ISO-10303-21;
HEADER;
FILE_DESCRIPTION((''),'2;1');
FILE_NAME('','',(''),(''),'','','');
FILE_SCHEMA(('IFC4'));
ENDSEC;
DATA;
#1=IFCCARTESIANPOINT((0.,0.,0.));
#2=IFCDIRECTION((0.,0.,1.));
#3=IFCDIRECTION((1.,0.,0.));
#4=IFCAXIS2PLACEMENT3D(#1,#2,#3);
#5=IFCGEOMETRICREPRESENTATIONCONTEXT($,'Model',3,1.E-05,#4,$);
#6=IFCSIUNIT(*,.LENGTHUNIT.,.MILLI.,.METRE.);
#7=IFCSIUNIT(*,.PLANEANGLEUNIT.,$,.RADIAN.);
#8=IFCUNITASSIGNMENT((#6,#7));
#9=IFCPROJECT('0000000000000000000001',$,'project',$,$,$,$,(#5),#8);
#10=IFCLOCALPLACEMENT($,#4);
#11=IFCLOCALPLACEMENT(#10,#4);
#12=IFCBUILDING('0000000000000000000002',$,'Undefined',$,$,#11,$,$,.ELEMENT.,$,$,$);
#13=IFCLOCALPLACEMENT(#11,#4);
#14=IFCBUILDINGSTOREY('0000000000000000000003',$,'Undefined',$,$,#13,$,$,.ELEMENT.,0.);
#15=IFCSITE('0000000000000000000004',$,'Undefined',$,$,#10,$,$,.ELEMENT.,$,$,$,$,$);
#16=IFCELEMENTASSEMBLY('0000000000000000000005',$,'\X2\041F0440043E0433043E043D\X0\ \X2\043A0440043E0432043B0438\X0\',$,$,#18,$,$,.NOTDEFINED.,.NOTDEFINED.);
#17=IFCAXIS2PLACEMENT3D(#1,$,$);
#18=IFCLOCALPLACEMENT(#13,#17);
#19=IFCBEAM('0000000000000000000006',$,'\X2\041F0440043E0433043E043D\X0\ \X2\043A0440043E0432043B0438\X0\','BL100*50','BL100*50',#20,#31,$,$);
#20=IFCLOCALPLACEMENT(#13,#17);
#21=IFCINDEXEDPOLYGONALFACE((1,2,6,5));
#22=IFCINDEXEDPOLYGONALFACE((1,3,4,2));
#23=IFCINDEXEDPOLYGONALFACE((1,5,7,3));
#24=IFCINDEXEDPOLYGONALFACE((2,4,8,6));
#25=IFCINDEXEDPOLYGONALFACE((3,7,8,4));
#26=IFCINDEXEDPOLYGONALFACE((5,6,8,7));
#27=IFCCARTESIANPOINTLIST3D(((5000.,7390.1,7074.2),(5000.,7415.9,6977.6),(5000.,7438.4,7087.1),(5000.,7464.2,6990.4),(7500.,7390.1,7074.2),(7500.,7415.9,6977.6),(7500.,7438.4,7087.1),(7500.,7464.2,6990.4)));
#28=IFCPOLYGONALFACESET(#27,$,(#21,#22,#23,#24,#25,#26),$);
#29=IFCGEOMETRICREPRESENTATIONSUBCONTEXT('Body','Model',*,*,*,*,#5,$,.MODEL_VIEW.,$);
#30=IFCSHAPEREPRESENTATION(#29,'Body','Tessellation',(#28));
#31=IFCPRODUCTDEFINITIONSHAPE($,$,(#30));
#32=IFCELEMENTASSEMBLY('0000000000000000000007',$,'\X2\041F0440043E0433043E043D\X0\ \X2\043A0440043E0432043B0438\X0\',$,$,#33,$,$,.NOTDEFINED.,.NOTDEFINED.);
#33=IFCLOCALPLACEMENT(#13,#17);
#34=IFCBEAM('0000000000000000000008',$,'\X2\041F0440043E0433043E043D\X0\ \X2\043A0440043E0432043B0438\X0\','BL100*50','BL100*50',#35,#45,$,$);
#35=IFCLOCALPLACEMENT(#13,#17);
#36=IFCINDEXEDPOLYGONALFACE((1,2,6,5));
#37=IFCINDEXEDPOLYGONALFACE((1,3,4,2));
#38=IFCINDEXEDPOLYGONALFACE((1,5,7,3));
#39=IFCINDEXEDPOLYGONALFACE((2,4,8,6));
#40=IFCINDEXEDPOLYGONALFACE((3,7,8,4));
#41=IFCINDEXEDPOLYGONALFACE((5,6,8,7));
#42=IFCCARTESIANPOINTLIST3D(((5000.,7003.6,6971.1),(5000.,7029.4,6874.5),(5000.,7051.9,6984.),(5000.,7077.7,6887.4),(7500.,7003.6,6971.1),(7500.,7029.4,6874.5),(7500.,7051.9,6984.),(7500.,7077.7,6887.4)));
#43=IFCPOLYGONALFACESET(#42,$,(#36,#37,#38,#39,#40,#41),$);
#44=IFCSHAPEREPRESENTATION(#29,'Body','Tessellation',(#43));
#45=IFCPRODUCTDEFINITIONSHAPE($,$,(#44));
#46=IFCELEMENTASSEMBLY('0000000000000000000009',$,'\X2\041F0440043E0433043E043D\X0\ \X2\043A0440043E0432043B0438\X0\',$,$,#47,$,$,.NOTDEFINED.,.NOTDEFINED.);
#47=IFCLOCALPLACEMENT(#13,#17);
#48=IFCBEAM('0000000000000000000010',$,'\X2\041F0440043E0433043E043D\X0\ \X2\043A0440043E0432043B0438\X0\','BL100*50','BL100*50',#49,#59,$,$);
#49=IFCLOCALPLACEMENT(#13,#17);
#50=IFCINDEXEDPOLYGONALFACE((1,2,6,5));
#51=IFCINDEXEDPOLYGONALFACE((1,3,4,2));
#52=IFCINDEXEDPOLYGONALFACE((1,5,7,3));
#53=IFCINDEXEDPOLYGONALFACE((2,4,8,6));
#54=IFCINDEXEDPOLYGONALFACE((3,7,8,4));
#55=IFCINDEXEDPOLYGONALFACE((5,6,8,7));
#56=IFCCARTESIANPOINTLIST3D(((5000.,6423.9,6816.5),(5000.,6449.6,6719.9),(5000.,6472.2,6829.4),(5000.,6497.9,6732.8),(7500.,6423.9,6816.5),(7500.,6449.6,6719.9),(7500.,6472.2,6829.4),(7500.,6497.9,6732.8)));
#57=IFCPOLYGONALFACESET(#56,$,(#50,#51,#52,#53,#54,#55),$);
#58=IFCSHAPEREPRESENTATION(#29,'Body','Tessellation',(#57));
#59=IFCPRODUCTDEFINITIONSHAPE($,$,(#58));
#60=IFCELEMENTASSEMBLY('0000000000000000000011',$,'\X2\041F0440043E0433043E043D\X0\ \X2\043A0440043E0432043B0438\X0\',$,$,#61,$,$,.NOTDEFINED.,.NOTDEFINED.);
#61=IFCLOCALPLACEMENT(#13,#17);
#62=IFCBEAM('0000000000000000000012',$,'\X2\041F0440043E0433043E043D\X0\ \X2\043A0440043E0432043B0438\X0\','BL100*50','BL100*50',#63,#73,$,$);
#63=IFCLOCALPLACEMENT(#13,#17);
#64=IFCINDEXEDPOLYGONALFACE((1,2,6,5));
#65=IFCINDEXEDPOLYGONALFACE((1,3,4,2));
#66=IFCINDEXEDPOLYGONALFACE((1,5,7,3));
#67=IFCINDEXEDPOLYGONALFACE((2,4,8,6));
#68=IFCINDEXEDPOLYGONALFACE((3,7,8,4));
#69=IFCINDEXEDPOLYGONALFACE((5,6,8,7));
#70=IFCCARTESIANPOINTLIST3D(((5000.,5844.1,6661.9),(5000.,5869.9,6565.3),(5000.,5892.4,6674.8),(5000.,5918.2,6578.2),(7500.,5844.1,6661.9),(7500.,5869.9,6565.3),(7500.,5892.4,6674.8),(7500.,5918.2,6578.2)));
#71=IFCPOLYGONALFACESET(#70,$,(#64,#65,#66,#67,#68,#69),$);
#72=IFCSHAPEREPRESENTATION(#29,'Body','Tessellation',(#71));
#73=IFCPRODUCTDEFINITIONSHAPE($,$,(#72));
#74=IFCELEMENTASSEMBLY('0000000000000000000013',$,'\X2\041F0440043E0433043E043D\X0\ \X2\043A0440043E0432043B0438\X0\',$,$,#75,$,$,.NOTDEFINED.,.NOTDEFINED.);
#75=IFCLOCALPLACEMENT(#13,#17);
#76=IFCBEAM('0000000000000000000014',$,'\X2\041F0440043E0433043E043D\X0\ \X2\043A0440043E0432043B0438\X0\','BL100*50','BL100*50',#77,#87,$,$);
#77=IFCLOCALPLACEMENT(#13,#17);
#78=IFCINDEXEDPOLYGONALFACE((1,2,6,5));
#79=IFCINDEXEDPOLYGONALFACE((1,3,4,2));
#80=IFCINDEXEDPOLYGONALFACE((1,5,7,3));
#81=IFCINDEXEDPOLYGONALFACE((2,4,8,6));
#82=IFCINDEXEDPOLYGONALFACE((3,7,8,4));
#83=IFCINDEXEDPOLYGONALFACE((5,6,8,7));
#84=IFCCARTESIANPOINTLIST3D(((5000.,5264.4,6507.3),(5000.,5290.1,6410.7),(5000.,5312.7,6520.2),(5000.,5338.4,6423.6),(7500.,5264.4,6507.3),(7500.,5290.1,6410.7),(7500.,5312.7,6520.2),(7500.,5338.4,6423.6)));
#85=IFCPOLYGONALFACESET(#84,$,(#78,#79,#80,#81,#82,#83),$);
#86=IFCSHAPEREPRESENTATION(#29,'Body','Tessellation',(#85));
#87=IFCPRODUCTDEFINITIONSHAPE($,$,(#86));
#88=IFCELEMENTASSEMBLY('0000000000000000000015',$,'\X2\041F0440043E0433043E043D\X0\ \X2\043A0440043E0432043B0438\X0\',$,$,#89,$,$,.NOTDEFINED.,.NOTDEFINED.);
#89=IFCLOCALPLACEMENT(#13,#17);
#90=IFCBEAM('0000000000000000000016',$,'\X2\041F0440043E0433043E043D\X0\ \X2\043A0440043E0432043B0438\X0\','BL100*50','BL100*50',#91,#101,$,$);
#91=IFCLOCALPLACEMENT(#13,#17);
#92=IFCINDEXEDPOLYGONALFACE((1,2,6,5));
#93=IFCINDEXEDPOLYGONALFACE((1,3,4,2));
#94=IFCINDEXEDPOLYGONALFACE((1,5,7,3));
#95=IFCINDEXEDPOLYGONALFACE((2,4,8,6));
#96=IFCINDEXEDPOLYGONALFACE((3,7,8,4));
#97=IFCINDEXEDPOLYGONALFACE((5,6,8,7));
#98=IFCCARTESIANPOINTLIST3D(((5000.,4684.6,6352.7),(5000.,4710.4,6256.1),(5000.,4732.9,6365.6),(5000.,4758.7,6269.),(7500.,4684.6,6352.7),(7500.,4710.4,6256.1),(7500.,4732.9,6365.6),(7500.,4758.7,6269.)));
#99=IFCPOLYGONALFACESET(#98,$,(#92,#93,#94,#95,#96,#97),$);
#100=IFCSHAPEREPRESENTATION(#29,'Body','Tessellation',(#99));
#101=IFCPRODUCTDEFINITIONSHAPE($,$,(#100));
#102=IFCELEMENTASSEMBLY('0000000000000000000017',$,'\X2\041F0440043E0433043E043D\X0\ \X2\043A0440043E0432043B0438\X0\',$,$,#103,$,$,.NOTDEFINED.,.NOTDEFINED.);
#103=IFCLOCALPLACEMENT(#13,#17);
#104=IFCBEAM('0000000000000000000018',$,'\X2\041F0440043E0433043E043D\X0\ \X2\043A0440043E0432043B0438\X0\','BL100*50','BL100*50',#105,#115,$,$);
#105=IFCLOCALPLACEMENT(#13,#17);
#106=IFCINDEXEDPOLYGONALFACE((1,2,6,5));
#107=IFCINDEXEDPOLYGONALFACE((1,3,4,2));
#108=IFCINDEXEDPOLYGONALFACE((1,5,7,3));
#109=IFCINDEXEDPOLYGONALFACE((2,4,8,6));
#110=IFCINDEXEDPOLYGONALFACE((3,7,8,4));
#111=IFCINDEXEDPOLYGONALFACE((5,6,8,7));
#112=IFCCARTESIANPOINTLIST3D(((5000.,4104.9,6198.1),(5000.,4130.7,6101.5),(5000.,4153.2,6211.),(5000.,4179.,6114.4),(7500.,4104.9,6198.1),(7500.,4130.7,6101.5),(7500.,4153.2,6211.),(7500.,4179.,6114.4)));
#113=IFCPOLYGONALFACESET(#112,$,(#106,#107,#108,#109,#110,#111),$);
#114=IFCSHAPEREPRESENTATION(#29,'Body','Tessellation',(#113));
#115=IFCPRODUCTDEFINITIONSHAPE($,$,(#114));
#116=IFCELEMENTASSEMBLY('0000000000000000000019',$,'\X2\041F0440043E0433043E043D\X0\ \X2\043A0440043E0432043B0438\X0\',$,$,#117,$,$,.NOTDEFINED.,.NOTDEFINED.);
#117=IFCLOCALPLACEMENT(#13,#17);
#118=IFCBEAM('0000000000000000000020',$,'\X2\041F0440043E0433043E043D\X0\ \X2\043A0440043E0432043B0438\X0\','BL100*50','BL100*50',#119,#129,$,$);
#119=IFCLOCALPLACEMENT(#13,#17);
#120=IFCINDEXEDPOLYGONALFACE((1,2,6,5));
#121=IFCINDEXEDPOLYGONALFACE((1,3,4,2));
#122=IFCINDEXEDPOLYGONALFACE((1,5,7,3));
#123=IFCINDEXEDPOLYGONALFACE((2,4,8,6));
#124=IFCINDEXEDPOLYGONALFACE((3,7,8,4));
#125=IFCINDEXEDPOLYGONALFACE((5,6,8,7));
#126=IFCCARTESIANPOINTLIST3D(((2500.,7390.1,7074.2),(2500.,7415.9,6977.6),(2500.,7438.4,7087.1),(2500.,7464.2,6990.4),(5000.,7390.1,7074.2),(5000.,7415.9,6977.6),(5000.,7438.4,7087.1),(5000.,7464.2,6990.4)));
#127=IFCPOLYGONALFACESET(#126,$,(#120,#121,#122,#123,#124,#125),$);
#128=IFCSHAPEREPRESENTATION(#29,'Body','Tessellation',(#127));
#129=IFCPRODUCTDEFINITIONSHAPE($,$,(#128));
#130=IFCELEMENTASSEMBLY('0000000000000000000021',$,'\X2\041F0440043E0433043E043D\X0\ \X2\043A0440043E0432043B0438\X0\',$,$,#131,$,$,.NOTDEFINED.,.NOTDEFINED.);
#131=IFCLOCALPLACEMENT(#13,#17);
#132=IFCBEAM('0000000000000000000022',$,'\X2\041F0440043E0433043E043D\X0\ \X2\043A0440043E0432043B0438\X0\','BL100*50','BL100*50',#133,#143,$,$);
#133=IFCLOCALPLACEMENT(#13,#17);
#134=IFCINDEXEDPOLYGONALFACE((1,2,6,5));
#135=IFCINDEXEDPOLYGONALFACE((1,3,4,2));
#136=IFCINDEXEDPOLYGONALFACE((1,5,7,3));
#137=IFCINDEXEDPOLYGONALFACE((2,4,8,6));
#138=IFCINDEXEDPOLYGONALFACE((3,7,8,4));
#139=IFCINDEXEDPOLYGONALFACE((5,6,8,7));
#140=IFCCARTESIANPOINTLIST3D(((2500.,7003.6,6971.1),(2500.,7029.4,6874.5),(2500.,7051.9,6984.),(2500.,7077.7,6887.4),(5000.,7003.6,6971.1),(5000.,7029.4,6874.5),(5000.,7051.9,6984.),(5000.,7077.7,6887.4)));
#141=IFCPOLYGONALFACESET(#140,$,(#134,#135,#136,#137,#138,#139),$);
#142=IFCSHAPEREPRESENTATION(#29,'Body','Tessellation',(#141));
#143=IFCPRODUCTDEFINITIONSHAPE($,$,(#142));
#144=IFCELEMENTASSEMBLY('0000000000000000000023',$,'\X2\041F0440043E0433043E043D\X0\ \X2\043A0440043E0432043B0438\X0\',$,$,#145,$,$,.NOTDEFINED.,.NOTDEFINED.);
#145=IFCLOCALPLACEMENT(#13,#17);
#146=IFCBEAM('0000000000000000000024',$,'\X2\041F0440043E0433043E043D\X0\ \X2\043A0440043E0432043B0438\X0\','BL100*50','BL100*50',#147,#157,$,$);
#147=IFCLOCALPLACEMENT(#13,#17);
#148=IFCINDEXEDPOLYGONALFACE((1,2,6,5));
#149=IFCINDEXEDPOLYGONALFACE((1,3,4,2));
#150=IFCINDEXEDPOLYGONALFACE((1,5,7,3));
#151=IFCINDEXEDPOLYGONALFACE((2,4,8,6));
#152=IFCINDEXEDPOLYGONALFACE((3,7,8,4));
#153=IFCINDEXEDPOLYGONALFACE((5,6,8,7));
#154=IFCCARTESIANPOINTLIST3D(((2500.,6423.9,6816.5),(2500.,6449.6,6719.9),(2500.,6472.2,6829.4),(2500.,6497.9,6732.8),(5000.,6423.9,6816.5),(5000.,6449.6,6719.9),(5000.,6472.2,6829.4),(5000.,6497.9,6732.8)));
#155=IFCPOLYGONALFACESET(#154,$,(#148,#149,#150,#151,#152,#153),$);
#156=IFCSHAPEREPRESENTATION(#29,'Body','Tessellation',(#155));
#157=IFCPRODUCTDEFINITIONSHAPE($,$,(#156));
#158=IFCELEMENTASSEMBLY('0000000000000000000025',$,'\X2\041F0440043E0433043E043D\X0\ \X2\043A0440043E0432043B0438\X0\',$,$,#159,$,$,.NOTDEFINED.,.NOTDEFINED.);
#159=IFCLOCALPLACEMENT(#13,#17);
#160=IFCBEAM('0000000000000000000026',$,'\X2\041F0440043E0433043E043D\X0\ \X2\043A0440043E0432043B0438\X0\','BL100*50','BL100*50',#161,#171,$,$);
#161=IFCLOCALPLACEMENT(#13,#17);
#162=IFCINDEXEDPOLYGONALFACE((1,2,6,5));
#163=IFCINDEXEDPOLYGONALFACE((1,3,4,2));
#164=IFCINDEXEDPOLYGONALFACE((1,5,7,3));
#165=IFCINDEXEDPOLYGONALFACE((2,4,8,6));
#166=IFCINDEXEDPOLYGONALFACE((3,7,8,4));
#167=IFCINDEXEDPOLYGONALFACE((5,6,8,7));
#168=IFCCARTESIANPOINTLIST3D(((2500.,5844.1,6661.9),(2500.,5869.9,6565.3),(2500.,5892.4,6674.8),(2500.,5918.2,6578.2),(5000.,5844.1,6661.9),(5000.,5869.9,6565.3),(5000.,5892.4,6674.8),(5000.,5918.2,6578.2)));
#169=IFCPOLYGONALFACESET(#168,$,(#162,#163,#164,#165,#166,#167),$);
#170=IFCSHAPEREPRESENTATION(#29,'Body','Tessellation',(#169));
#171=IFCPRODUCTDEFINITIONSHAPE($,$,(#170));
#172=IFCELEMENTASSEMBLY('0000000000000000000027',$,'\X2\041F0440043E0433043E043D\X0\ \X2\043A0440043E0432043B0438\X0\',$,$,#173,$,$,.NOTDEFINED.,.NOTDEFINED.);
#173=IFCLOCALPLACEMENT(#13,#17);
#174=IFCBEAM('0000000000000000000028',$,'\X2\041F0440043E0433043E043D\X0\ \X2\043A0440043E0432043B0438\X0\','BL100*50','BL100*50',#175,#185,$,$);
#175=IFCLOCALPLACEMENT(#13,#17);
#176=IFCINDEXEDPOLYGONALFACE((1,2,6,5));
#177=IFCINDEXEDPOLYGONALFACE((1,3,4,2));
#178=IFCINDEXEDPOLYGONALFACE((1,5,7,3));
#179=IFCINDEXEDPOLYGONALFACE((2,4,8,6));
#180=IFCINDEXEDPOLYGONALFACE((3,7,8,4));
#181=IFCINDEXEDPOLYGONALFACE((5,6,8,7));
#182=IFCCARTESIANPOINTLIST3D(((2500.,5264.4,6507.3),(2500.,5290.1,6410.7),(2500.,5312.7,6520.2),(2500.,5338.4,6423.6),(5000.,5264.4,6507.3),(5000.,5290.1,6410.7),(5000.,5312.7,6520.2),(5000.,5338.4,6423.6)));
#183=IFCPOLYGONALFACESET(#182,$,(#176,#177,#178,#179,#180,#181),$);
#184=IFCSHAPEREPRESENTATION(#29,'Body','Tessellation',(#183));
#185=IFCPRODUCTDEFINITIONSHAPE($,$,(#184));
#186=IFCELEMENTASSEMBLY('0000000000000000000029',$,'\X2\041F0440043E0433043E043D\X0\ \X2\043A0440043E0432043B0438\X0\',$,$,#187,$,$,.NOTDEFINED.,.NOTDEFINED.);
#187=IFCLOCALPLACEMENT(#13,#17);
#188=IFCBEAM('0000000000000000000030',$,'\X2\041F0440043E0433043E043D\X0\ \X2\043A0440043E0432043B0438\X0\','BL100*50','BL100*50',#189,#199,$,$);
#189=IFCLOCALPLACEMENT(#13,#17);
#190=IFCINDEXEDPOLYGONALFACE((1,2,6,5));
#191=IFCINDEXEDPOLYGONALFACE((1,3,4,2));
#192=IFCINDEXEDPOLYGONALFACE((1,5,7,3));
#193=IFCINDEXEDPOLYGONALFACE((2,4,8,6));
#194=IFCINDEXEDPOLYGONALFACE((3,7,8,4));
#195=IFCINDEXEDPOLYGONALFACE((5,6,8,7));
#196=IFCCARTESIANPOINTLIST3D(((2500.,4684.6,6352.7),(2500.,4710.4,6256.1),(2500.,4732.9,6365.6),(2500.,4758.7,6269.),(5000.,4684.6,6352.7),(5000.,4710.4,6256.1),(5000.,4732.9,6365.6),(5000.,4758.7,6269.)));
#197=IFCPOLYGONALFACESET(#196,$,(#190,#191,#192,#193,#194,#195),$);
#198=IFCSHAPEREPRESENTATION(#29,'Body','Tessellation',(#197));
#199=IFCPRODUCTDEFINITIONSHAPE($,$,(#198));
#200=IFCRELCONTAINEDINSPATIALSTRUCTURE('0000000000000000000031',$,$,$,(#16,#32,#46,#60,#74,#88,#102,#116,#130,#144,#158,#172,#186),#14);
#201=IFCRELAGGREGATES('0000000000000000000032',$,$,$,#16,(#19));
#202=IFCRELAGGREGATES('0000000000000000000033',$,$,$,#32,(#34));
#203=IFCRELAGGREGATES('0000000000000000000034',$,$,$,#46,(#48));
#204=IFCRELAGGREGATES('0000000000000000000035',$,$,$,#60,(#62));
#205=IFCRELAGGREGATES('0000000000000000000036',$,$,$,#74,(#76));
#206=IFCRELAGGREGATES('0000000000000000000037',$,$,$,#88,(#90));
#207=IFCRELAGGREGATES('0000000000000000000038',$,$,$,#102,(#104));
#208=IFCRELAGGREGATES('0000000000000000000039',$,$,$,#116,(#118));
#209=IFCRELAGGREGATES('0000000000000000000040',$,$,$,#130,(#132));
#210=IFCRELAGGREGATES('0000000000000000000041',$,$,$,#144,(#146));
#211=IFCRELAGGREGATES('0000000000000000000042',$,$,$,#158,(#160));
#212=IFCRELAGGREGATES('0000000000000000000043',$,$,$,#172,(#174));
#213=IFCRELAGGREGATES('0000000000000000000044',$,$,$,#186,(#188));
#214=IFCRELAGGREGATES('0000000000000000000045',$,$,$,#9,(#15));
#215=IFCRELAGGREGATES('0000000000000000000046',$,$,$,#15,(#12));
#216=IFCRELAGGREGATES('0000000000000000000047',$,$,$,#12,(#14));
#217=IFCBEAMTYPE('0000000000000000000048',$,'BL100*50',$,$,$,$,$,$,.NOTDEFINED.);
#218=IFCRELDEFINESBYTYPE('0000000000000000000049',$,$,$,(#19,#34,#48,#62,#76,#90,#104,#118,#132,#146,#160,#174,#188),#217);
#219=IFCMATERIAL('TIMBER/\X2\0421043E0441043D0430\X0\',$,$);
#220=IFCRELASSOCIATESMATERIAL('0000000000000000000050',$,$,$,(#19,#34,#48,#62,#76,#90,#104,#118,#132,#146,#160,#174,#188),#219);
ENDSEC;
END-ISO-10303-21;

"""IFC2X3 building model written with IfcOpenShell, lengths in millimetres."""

from ifc_helpers import new_model, si_unit, frame, origin_with_axes, origin_2d_with_axis, place, context, subcontext, project, spatial, rectangle, extrude, material, type_object, element, aggregate, save


model = new_model("IFC2X3")

# Units and contexts
model_context = context("Model", 3, precision=1e-05, world=origin_with_axes())
body_context = subcontext(model_context, "Body", "Model", "MODEL_VIEW")
ifc_project = project(units=[si_unit("LENGTHUNIT", "METRE", prefix="MILLI"), si_unit("PLANEANGLEUNIT", "RADIAN")], contexts=[model_context])

# Site, building, storey
site_placement = place(None, origin_with_axes())
site = spatial("IfcSite", under=ifc_project, at=site_placement, Name="Undefined", CompositionType="ELEMENT")
building_placement = place(site_placement, origin_with_axes())
building = spatial("IfcBuilding", under=site, at=building_placement, Name="Undefined", CompositionType="ELEMENT")
storey_placement = place(building_placement, origin_with_axes())
storey = spatial("IfcBuildingStorey", under=building, at=storey_placement, Name="Undefined", CompositionType="ELEMENT", Elevation=0.0)

# Element assemblies, beams
assembly_1_placement = place(storey_placement, origin_with_axes())
assembly_1 = element("IfcElementAssembly", 1, at=assembly_1_placement, inside=storey, Name="Прогон кровли", AssemblyPlace="NOTDEFINED", PredefinedType="NOTDEFINED")
ifc_material_1 = material(Name="TIMBER/Сосна")
beam_type = type_object("IfcBeamType", Name="BL100*50", PredefinedType="NOTDEFINED")
beam_1_placement = place(assembly_1_placement, frame((5000.0, 7427.1, 7032.3), z_axis=(0.0, 0.257663, -0.966235), x_axis=(1.0, 0.0, 0.0)))
beam_1 = element("IfcBeam", 2, at=beam_1_placement, type_object=beam_type, material=ifc_material_1, Name="Прогон кровли", Description="BL100*50", ObjectType="BL100*50", context=body_context, shape_type="SweptSolid", body=[
    extrude(rectangle(XDim=50.0, YDim=100.0, at=origin_2d_with_axis()), frame((2500.0, 0.0, 0.0), z_axis=(-1.0, 0.0, 0.0), x_axis=(0.0, -1.0, 0.0)), (0.0, 0.0, 1.0), 2500.0),
])
aggregate(assembly_1, [beam_1])
assembly_2_placement = place(storey_placement, origin_with_axes())
assembly_2 = element("IfcElementAssembly", 3, at=assembly_2_placement, inside=storey, Name="Прогон кровли", AssemblyPlace="NOTDEFINED", PredefinedType="NOTDEFINED")
beam_2_placement = place(assembly_2_placement, frame((5000.0, 7040.6, 6929.2), z_axis=(0.0, 0.257663, -0.966235), x_axis=(1.0, 0.0, 0.0)))
beam_2 = element("IfcBeam", 4, at=beam_2_placement, type_object=beam_type, material=ifc_material_1, Name="Прогон кровли", Description="BL100*50", ObjectType="BL100*50", context=body_context, shape_type="SweptSolid", body=[
    extrude(rectangle(XDim=50.0, YDim=100.0, at=origin_2d_with_axis()), frame((2500.0, 0.0, 0.0), z_axis=(-1.0, 0.0, 0.0), x_axis=(0.0, -1.0, 0.0)), (0.0, 0.0, 1.0), 2500.0),
])
aggregate(assembly_2, [beam_2])
assembly_3_placement = place(storey_placement, origin_with_axes())
assembly_3 = element("IfcElementAssembly", 5, at=assembly_3_placement, inside=storey, Name="Прогон кровли", AssemblyPlace="NOTDEFINED", PredefinedType="NOTDEFINED")
beam_3_placement = place(assembly_3_placement, frame((5000.0, 6460.9, 6774.7), z_axis=(0.0, 0.257663, -0.966235), x_axis=(1.0, 0.0, 0.0)))
beam_3 = element("IfcBeam", 6, at=beam_3_placement, type_object=beam_type, material=ifc_material_1, Name="Прогон кровли", Description="BL100*50", ObjectType="BL100*50", context=body_context, shape_type="SweptSolid", body=[
    extrude(rectangle(XDim=50.0, YDim=100.0, at=origin_2d_with_axis()), frame((2500.0, 0.0, 0.0), z_axis=(-1.0, 0.0, 0.0), x_axis=(0.0, -1.0, 0.0)), (0.0, 0.0, 1.0), 2500.0),
])
aggregate(assembly_3, [beam_3])
assembly_4_placement = place(storey_placement, origin_with_axes())
assembly_4 = element("IfcElementAssembly", 7, at=assembly_4_placement, inside=storey, Name="Прогон кровли", AssemblyPlace="NOTDEFINED", PredefinedType="NOTDEFINED")
beam_4_placement = place(assembly_4_placement, frame((5000.0, 5881.1, 6620.1), z_axis=(0.0, 0.257663, -0.966235), x_axis=(1.0, 0.0, 0.0)))
beam_4 = element("IfcBeam", 8, at=beam_4_placement, type_object=beam_type, material=ifc_material_1, Name="Прогон кровли", Description="BL100*50", ObjectType="BL100*50", context=body_context, shape_type="SweptSolid", body=[
    extrude(rectangle(XDim=50.0, YDim=100.0, at=origin_2d_with_axis()), frame((2500.0, 0.0, 0.0), z_axis=(-1.0, 0.0, 0.0), x_axis=(0.0, -1.0, 0.0)), (0.0, 0.0, 1.0), 2500.0),
])
aggregate(assembly_4, [beam_4])
assembly_5_placement = place(storey_placement, origin_with_axes())
assembly_5 = element("IfcElementAssembly", 9, at=assembly_5_placement, inside=storey, Name="Прогон кровли", AssemblyPlace="NOTDEFINED", PredefinedType="NOTDEFINED")
beam_5_placement = place(assembly_5_placement, frame((5000.0, 5301.4, 6465.5), z_axis=(0.0, 0.257663, -0.966235), x_axis=(1.0, 0.0, 0.0)))
beam_5 = element("IfcBeam", 10, at=beam_5_placement, type_object=beam_type, material=ifc_material_1, Name="Прогон кровли", Description="BL100*50", ObjectType="BL100*50", context=body_context, shape_type="SweptSolid", body=[
    extrude(rectangle(XDim=50.0, YDim=100.0, at=origin_2d_with_axis()), frame((2500.0, 0.0, 0.0), z_axis=(-1.0, 0.0, 0.0), x_axis=(0.0, -1.0, 0.0)), (0.0, 0.0, 1.0), 2500.0),
])
aggregate(assembly_5, [beam_5])
assembly_6_placement = place(storey_placement, origin_with_axes())
assembly_6 = element("IfcElementAssembly", 11, at=assembly_6_placement, inside=storey, Name="Прогон кровли", AssemblyPlace="NOTDEFINED", PredefinedType="NOTDEFINED")
beam_6_placement = place(assembly_6_placement, frame((5000.0, 4721.7, 6310.9), z_axis=(0.0, 0.257663, -0.966235), x_axis=(1.0, 0.0, 0.0)))
beam_6 = element("IfcBeam", 12, at=beam_6_placement, type_object=beam_type, material=ifc_material_1, Name="Прогон кровли", Description="BL100*50", ObjectType="BL100*50", context=body_context, shape_type="SweptSolid", body=[
    extrude(rectangle(XDim=50.0, YDim=100.0, at=origin_2d_with_axis()), frame((2500.0, 0.0, 0.0), z_axis=(-1.0, 0.0, 0.0), x_axis=(0.0, -1.0, 0.0)), (0.0, 0.0, 1.0), 2500.0),
])
aggregate(assembly_6, [beam_6])
assembly_7_placement = place(storey_placement, origin_with_axes())
assembly_7 = element("IfcElementAssembly", 13, at=assembly_7_placement, inside=storey, Name="Прогон кровли", AssemblyPlace="NOTDEFINED", PredefinedType="NOTDEFINED")
beam_7_placement = place(assembly_7_placement, frame((5000.0, 4141.9, 6156.3), z_axis=(0.0, 0.257663, -0.966235), x_axis=(1.0, 0.0, 0.0)))
beam_7 = element("IfcBeam", 14, at=beam_7_placement, type_object=beam_type, material=ifc_material_1, Name="Прогон кровли", Description="BL100*50", ObjectType="BL100*50", context=body_context, shape_type="SweptSolid", body=[
    extrude(rectangle(XDim=50.0, YDim=100.0, at=origin_2d_with_axis()), frame((2500.0, 0.0, 0.0), z_axis=(-1.0, 0.0, 0.0), x_axis=(0.0, -1.0, 0.0)), (0.0, 0.0, 1.0), 2500.0),
])
aggregate(assembly_7, [beam_7])
assembly_8_placement = place(storey_placement, origin_with_axes())
assembly_8 = element("IfcElementAssembly", 15, at=assembly_8_placement, inside=storey, Name="Прогон кровли", AssemblyPlace="NOTDEFINED", PredefinedType="NOTDEFINED")
beam_8_placement = place(assembly_8_placement, frame((2500.0, 7427.1, 7032.3), z_axis=(0.0, 0.257663, -0.966235), x_axis=(1.0, 0.0, 0.0)))
beam_8 = element("IfcBeam", 16, at=beam_8_placement, type_object=beam_type, material=ifc_material_1, Name="Прогон кровли", Description="BL100*50", ObjectType="BL100*50", context=body_context, shape_type="SweptSolid", body=[
    extrude(rectangle(XDim=50.0, YDim=100.0, at=origin_2d_with_axis()), frame((2500.0, 0.0, 0.0), z_axis=(-1.0, 0.0, 0.0), x_axis=(0.0, -1.0, 0.0)), (0.0, 0.0, 1.0), 2500.0),
])
aggregate(assembly_8, [beam_8])
assembly_9_placement = place(storey_placement, origin_with_axes())
assembly_9 = element("IfcElementAssembly", 17, at=assembly_9_placement, inside=storey, Name="Прогон кровли", AssemblyPlace="NOTDEFINED", PredefinedType="NOTDEFINED")
beam_9_placement = place(assembly_9_placement, frame((2500.0, 7040.6, 6929.2), z_axis=(0.0, 0.257663, -0.966235), x_axis=(1.0, 0.0, 0.0)))
beam_9 = element("IfcBeam", 18, at=beam_9_placement, type_object=beam_type, material=ifc_material_1, Name="Прогон кровли", Description="BL100*50", ObjectType="BL100*50", context=body_context, shape_type="SweptSolid", body=[
    extrude(rectangle(XDim=50.0, YDim=100.0, at=origin_2d_with_axis()), frame((2500.0, 0.0, 0.0), z_axis=(-1.0, 0.0, 0.0), x_axis=(0.0, -1.0, 0.0)), (0.0, 0.0, 1.0), 2500.0),
])
aggregate(assembly_9, [beam_9])
assembly_10_placement = place(storey_placement, origin_with_axes())
assembly_10 = element("IfcElementAssembly", 19, at=assembly_10_placement, inside=storey, Name="Прогон кровли", AssemblyPlace="NOTDEFINED", PredefinedType="NOTDEFINED")
beam_10_placement = place(assembly_10_placement, frame((2500.0, 6460.9, 6774.7), z_axis=(0.0, 0.257663, -0.966235), x_axis=(1.0, 0.0, 0.0)))
beam_10 = element("IfcBeam", 20, at=beam_10_placement, type_object=beam_type, material=ifc_material_1, Name="Прогон кровли", Description="BL100*50", ObjectType="BL100*50", context=body_context, shape_type="SweptSolid", body=[
    extrude(rectangle(XDim=50.0, YDim=100.0, at=origin_2d_with_axis()), frame((2500.0, 0.0, 0.0), z_axis=(-1.0, 0.0, 0.0), x_axis=(0.0, -1.0, 0.0)), (0.0, 0.0, 1.0), 2500.0),
])
aggregate(assembly_10, [beam_10])
assembly_11_placement = place(storey_placement, origin_with_axes())
assembly_11 = element("IfcElementAssembly", 21, at=assembly_11_placement, inside=storey, Name="Прогон кровли", AssemblyPlace="NOTDEFINED", PredefinedType="NOTDEFINED")
beam_11_placement = place(assembly_11_placement, frame((2500.0, 5881.1, 6620.1), z_axis=(0.0, 0.257663, -0.966235), x_axis=(1.0, 0.0, 0.0)))
beam_11 = element("IfcBeam", 22, at=beam_11_placement, type_object=beam_type, material=ifc_material_1, Name="Прогон кровли", Description="BL100*50", ObjectType="BL100*50", context=body_context, shape_type="SweptSolid", body=[
    extrude(rectangle(XDim=50.0, YDim=100.0, at=origin_2d_with_axis()), frame((2500.0, 0.0, 0.0), z_axis=(-1.0, 0.0, 0.0), x_axis=(0.0, -1.0, 0.0)), (0.0, 0.0, 1.0), 2500.0),
])
aggregate(assembly_11, [beam_11])
assembly_12_placement = place(storey_placement, origin_with_axes())
assembly_12 = element("IfcElementAssembly", 23, at=assembly_12_placement, inside=storey, Name="Прогон кровли", AssemblyPlace="NOTDEFINED", PredefinedType="NOTDEFINED")
beam_12_placement = place(assembly_12_placement, frame((2500.0, 5301.4, 6465.5), z_axis=(0.0, 0.257663, -0.966235), x_axis=(1.0, 0.0, 0.0)))
beam_12 = element("IfcBeam", 24, at=beam_12_placement, type_object=beam_type, material=ifc_material_1, Name="Прогон кровли", Description="BL100*50", ObjectType="BL100*50", context=body_context, shape_type="SweptSolid", body=[
    extrude(rectangle(XDim=50.0, YDim=100.0, at=origin_2d_with_axis()), frame((2500.0, 0.0, 0.0), z_axis=(-1.0, 0.0, 0.0), x_axis=(0.0, -1.0, 0.0)), (0.0, 0.0, 1.0), 2500.0),
])
aggregate(assembly_12, [beam_12])
assembly_13_placement = place(storey_placement, origin_with_axes())
assembly_13 = element("IfcElementAssembly", 25, at=assembly_13_placement, inside=storey, Name="Прогон кровли", AssemblyPlace="NOTDEFINED", PredefinedType="NOTDEFINED")
beam_13_placement = place(assembly_13_placement, frame((2500.0, 4721.7, 6310.9), z_axis=(0.0, 0.257663, -0.966235), x_axis=(1.0, 0.0, 0.0)))
beam_13 = element("IfcBeam", 26, at=beam_13_placement, type_object=beam_type, material=ifc_material_1, Name="Прогон кровли", Description="BL100*50", ObjectType="BL100*50", context=body_context, shape_type="SweptSolid", body=[
    extrude(rectangle(XDim=50.0, YDim=100.0, at=origin_2d_with_axis()), frame((2500.0, 0.0, 0.0), z_axis=(-1.0, 0.0, 0.0), x_axis=(0.0, -1.0, 0.0)), (0.0, 0.0, 1.0), 2500.0),
])
aggregate(assembly_13, [beam_13])

save(model, "model.ifc")
